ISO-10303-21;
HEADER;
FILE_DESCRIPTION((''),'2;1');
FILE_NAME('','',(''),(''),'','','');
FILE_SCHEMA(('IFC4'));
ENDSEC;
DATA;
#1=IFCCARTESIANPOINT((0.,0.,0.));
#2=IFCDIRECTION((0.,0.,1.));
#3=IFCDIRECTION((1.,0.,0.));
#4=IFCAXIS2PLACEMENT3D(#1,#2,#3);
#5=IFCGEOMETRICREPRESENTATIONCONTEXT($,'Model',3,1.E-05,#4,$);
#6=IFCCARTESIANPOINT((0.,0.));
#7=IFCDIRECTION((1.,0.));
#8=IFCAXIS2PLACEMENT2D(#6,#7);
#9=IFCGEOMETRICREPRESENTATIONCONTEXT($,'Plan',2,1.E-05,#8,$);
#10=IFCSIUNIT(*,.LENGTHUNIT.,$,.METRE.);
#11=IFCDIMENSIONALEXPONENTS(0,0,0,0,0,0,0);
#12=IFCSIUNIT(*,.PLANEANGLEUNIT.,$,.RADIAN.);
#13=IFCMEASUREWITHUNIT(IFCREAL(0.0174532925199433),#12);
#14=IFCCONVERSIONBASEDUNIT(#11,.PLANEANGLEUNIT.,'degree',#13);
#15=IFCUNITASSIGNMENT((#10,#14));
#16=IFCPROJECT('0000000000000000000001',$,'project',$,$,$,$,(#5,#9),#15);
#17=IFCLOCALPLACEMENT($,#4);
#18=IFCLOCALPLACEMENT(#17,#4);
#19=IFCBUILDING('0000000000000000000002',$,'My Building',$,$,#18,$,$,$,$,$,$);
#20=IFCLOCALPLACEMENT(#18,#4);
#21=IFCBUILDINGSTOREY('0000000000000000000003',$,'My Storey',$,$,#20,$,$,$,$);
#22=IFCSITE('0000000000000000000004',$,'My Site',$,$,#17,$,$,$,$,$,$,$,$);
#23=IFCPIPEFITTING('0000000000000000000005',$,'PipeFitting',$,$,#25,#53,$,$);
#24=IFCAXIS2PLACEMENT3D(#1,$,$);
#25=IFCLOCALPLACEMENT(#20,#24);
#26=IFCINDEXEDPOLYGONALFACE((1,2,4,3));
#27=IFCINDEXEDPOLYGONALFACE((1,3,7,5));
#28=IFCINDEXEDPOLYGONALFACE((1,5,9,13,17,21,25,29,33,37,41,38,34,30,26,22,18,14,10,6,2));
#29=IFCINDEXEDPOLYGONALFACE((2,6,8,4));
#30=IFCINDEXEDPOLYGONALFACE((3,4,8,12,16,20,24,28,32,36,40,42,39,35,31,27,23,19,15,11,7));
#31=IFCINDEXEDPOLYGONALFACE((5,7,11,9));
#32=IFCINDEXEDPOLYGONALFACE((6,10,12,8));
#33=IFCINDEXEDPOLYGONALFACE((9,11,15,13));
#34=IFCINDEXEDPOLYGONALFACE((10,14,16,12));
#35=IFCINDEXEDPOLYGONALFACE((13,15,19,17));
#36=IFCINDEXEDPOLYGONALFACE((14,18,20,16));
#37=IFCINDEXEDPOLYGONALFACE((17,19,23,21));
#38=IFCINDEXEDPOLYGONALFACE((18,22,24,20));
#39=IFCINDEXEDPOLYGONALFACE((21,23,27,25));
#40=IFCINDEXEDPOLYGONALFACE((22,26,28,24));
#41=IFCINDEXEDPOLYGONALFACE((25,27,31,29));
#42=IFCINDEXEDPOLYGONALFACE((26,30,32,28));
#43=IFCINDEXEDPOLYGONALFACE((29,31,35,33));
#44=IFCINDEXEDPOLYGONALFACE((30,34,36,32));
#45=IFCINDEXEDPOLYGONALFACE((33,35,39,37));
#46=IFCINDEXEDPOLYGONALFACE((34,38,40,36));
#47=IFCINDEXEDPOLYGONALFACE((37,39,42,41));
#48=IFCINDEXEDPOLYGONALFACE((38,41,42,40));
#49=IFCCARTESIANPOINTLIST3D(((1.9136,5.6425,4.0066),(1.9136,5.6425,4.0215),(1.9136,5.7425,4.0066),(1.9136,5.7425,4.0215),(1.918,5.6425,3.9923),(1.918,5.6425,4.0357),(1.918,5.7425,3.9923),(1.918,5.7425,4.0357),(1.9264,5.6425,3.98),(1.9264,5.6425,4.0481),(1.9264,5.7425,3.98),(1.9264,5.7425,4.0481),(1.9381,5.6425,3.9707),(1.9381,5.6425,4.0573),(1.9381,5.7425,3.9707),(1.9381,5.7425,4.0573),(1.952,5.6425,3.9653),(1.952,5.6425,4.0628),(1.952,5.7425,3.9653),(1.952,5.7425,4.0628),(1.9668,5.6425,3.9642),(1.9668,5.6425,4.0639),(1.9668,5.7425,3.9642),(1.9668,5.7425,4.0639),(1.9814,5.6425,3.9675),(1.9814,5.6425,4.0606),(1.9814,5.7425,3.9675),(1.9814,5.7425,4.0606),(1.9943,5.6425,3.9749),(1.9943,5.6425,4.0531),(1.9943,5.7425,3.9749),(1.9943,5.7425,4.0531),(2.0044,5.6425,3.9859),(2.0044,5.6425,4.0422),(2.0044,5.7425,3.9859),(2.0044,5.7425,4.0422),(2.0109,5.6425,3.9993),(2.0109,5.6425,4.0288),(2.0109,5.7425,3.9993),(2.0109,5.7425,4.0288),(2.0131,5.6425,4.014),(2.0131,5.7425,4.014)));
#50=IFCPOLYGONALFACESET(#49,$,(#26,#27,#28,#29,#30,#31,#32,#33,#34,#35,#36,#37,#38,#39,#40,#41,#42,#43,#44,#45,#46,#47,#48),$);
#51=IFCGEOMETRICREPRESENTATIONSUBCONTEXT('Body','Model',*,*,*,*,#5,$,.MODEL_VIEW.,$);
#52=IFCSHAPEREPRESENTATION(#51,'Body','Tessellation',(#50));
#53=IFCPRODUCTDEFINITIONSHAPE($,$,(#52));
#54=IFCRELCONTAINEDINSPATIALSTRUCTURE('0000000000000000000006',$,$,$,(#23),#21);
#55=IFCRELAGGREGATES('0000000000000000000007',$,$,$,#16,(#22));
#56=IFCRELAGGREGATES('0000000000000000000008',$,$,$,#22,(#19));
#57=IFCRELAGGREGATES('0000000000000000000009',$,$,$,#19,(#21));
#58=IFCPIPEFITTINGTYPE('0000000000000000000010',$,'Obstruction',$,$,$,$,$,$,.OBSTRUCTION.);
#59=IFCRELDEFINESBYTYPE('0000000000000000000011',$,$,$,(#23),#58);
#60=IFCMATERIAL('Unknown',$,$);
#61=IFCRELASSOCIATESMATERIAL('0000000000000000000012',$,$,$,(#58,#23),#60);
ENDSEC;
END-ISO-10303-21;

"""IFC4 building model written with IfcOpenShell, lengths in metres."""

from ifc_helpers import new_model, entity, si_unit, converted_unit, frame, origin_with_axes, origin_2d_with_axis, place, context, subcontext, project, spatial, circle, extrude, material, material_profile, profile_set, profile_usage, type_object, element, save


model = new_model("IFC4")

# Units and contexts
model_context = context("Model", 3, precision=1e-05, world=origin_with_axes())
plan_context = context("Plan", 2, precision=1e-05, world=origin_2d_with_axis())
body_context = subcontext(model_context, "Body", "Model", "MODEL_VIEW")
ifc_project = project(units=[si_unit("LENGTHUNIT", "METRE"), converted_unit("PLANEANGLEUNIT", "degree", entity("IfcReal", 0.0174532925199433), si_unit("PLANEANGLEUNIT", "RADIAN"), dimensions=[0, 0, 0, 0, 0, 0, 0])], contexts=[model_context, plan_context])

# Site, building, storey
site_placement = place(None, origin_with_axes())
site = spatial("IfcSite", under=ifc_project, at=site_placement, Name="My Site")
building_placement = place(site_placement, origin_with_axes())
building = spatial("IfcBuilding", under=site, at=building_placement, Name="My Building")
storey_placement = place(building_placement, origin_with_axes())
storey = spatial("IfcBuildingStorey", under=building, at=storey_placement, Name="My Storey")

# Shared definitions
ifc_material = material(Name="Unknown")

# Pipe fitting
ifc_material_profile_1 = material_profile(ifc_material, circle(Radius=0.05))
ifc_profile_set_1 = profile_set([ifc_material_profile_1])
pipe_fitting_type_1 = type_object("IfcPipeFittingType", Name="Obstruction", PredefinedType="OBSTRUCTION", material=ifc_profile_set_1)
ifc_profile_usage_1 = profile_usage(ifc_profile_set_1, cardinal=5)
pipe_fitting_1_placement = place(storey_placement, frame((1.9631, 5.7425, 4.014), z_axis=(0.0, -1.0, 0.0), x_axis=(1.0, 0.0, 0.0)))
element("IfcPipeFitting", 1, at=pipe_fitting_1_placement, inside=storey, type_object=pipe_fitting_type_1, material=ifc_profile_usage_1, Name="PipeFitting", context=body_context, shape_type="SweptSolid", body=[
    extrude(circle(Radius=0.05), origin_with_axes(), (0.0, 0.0, 1.0), 0.1),
])

save(model, "model.ifc")
